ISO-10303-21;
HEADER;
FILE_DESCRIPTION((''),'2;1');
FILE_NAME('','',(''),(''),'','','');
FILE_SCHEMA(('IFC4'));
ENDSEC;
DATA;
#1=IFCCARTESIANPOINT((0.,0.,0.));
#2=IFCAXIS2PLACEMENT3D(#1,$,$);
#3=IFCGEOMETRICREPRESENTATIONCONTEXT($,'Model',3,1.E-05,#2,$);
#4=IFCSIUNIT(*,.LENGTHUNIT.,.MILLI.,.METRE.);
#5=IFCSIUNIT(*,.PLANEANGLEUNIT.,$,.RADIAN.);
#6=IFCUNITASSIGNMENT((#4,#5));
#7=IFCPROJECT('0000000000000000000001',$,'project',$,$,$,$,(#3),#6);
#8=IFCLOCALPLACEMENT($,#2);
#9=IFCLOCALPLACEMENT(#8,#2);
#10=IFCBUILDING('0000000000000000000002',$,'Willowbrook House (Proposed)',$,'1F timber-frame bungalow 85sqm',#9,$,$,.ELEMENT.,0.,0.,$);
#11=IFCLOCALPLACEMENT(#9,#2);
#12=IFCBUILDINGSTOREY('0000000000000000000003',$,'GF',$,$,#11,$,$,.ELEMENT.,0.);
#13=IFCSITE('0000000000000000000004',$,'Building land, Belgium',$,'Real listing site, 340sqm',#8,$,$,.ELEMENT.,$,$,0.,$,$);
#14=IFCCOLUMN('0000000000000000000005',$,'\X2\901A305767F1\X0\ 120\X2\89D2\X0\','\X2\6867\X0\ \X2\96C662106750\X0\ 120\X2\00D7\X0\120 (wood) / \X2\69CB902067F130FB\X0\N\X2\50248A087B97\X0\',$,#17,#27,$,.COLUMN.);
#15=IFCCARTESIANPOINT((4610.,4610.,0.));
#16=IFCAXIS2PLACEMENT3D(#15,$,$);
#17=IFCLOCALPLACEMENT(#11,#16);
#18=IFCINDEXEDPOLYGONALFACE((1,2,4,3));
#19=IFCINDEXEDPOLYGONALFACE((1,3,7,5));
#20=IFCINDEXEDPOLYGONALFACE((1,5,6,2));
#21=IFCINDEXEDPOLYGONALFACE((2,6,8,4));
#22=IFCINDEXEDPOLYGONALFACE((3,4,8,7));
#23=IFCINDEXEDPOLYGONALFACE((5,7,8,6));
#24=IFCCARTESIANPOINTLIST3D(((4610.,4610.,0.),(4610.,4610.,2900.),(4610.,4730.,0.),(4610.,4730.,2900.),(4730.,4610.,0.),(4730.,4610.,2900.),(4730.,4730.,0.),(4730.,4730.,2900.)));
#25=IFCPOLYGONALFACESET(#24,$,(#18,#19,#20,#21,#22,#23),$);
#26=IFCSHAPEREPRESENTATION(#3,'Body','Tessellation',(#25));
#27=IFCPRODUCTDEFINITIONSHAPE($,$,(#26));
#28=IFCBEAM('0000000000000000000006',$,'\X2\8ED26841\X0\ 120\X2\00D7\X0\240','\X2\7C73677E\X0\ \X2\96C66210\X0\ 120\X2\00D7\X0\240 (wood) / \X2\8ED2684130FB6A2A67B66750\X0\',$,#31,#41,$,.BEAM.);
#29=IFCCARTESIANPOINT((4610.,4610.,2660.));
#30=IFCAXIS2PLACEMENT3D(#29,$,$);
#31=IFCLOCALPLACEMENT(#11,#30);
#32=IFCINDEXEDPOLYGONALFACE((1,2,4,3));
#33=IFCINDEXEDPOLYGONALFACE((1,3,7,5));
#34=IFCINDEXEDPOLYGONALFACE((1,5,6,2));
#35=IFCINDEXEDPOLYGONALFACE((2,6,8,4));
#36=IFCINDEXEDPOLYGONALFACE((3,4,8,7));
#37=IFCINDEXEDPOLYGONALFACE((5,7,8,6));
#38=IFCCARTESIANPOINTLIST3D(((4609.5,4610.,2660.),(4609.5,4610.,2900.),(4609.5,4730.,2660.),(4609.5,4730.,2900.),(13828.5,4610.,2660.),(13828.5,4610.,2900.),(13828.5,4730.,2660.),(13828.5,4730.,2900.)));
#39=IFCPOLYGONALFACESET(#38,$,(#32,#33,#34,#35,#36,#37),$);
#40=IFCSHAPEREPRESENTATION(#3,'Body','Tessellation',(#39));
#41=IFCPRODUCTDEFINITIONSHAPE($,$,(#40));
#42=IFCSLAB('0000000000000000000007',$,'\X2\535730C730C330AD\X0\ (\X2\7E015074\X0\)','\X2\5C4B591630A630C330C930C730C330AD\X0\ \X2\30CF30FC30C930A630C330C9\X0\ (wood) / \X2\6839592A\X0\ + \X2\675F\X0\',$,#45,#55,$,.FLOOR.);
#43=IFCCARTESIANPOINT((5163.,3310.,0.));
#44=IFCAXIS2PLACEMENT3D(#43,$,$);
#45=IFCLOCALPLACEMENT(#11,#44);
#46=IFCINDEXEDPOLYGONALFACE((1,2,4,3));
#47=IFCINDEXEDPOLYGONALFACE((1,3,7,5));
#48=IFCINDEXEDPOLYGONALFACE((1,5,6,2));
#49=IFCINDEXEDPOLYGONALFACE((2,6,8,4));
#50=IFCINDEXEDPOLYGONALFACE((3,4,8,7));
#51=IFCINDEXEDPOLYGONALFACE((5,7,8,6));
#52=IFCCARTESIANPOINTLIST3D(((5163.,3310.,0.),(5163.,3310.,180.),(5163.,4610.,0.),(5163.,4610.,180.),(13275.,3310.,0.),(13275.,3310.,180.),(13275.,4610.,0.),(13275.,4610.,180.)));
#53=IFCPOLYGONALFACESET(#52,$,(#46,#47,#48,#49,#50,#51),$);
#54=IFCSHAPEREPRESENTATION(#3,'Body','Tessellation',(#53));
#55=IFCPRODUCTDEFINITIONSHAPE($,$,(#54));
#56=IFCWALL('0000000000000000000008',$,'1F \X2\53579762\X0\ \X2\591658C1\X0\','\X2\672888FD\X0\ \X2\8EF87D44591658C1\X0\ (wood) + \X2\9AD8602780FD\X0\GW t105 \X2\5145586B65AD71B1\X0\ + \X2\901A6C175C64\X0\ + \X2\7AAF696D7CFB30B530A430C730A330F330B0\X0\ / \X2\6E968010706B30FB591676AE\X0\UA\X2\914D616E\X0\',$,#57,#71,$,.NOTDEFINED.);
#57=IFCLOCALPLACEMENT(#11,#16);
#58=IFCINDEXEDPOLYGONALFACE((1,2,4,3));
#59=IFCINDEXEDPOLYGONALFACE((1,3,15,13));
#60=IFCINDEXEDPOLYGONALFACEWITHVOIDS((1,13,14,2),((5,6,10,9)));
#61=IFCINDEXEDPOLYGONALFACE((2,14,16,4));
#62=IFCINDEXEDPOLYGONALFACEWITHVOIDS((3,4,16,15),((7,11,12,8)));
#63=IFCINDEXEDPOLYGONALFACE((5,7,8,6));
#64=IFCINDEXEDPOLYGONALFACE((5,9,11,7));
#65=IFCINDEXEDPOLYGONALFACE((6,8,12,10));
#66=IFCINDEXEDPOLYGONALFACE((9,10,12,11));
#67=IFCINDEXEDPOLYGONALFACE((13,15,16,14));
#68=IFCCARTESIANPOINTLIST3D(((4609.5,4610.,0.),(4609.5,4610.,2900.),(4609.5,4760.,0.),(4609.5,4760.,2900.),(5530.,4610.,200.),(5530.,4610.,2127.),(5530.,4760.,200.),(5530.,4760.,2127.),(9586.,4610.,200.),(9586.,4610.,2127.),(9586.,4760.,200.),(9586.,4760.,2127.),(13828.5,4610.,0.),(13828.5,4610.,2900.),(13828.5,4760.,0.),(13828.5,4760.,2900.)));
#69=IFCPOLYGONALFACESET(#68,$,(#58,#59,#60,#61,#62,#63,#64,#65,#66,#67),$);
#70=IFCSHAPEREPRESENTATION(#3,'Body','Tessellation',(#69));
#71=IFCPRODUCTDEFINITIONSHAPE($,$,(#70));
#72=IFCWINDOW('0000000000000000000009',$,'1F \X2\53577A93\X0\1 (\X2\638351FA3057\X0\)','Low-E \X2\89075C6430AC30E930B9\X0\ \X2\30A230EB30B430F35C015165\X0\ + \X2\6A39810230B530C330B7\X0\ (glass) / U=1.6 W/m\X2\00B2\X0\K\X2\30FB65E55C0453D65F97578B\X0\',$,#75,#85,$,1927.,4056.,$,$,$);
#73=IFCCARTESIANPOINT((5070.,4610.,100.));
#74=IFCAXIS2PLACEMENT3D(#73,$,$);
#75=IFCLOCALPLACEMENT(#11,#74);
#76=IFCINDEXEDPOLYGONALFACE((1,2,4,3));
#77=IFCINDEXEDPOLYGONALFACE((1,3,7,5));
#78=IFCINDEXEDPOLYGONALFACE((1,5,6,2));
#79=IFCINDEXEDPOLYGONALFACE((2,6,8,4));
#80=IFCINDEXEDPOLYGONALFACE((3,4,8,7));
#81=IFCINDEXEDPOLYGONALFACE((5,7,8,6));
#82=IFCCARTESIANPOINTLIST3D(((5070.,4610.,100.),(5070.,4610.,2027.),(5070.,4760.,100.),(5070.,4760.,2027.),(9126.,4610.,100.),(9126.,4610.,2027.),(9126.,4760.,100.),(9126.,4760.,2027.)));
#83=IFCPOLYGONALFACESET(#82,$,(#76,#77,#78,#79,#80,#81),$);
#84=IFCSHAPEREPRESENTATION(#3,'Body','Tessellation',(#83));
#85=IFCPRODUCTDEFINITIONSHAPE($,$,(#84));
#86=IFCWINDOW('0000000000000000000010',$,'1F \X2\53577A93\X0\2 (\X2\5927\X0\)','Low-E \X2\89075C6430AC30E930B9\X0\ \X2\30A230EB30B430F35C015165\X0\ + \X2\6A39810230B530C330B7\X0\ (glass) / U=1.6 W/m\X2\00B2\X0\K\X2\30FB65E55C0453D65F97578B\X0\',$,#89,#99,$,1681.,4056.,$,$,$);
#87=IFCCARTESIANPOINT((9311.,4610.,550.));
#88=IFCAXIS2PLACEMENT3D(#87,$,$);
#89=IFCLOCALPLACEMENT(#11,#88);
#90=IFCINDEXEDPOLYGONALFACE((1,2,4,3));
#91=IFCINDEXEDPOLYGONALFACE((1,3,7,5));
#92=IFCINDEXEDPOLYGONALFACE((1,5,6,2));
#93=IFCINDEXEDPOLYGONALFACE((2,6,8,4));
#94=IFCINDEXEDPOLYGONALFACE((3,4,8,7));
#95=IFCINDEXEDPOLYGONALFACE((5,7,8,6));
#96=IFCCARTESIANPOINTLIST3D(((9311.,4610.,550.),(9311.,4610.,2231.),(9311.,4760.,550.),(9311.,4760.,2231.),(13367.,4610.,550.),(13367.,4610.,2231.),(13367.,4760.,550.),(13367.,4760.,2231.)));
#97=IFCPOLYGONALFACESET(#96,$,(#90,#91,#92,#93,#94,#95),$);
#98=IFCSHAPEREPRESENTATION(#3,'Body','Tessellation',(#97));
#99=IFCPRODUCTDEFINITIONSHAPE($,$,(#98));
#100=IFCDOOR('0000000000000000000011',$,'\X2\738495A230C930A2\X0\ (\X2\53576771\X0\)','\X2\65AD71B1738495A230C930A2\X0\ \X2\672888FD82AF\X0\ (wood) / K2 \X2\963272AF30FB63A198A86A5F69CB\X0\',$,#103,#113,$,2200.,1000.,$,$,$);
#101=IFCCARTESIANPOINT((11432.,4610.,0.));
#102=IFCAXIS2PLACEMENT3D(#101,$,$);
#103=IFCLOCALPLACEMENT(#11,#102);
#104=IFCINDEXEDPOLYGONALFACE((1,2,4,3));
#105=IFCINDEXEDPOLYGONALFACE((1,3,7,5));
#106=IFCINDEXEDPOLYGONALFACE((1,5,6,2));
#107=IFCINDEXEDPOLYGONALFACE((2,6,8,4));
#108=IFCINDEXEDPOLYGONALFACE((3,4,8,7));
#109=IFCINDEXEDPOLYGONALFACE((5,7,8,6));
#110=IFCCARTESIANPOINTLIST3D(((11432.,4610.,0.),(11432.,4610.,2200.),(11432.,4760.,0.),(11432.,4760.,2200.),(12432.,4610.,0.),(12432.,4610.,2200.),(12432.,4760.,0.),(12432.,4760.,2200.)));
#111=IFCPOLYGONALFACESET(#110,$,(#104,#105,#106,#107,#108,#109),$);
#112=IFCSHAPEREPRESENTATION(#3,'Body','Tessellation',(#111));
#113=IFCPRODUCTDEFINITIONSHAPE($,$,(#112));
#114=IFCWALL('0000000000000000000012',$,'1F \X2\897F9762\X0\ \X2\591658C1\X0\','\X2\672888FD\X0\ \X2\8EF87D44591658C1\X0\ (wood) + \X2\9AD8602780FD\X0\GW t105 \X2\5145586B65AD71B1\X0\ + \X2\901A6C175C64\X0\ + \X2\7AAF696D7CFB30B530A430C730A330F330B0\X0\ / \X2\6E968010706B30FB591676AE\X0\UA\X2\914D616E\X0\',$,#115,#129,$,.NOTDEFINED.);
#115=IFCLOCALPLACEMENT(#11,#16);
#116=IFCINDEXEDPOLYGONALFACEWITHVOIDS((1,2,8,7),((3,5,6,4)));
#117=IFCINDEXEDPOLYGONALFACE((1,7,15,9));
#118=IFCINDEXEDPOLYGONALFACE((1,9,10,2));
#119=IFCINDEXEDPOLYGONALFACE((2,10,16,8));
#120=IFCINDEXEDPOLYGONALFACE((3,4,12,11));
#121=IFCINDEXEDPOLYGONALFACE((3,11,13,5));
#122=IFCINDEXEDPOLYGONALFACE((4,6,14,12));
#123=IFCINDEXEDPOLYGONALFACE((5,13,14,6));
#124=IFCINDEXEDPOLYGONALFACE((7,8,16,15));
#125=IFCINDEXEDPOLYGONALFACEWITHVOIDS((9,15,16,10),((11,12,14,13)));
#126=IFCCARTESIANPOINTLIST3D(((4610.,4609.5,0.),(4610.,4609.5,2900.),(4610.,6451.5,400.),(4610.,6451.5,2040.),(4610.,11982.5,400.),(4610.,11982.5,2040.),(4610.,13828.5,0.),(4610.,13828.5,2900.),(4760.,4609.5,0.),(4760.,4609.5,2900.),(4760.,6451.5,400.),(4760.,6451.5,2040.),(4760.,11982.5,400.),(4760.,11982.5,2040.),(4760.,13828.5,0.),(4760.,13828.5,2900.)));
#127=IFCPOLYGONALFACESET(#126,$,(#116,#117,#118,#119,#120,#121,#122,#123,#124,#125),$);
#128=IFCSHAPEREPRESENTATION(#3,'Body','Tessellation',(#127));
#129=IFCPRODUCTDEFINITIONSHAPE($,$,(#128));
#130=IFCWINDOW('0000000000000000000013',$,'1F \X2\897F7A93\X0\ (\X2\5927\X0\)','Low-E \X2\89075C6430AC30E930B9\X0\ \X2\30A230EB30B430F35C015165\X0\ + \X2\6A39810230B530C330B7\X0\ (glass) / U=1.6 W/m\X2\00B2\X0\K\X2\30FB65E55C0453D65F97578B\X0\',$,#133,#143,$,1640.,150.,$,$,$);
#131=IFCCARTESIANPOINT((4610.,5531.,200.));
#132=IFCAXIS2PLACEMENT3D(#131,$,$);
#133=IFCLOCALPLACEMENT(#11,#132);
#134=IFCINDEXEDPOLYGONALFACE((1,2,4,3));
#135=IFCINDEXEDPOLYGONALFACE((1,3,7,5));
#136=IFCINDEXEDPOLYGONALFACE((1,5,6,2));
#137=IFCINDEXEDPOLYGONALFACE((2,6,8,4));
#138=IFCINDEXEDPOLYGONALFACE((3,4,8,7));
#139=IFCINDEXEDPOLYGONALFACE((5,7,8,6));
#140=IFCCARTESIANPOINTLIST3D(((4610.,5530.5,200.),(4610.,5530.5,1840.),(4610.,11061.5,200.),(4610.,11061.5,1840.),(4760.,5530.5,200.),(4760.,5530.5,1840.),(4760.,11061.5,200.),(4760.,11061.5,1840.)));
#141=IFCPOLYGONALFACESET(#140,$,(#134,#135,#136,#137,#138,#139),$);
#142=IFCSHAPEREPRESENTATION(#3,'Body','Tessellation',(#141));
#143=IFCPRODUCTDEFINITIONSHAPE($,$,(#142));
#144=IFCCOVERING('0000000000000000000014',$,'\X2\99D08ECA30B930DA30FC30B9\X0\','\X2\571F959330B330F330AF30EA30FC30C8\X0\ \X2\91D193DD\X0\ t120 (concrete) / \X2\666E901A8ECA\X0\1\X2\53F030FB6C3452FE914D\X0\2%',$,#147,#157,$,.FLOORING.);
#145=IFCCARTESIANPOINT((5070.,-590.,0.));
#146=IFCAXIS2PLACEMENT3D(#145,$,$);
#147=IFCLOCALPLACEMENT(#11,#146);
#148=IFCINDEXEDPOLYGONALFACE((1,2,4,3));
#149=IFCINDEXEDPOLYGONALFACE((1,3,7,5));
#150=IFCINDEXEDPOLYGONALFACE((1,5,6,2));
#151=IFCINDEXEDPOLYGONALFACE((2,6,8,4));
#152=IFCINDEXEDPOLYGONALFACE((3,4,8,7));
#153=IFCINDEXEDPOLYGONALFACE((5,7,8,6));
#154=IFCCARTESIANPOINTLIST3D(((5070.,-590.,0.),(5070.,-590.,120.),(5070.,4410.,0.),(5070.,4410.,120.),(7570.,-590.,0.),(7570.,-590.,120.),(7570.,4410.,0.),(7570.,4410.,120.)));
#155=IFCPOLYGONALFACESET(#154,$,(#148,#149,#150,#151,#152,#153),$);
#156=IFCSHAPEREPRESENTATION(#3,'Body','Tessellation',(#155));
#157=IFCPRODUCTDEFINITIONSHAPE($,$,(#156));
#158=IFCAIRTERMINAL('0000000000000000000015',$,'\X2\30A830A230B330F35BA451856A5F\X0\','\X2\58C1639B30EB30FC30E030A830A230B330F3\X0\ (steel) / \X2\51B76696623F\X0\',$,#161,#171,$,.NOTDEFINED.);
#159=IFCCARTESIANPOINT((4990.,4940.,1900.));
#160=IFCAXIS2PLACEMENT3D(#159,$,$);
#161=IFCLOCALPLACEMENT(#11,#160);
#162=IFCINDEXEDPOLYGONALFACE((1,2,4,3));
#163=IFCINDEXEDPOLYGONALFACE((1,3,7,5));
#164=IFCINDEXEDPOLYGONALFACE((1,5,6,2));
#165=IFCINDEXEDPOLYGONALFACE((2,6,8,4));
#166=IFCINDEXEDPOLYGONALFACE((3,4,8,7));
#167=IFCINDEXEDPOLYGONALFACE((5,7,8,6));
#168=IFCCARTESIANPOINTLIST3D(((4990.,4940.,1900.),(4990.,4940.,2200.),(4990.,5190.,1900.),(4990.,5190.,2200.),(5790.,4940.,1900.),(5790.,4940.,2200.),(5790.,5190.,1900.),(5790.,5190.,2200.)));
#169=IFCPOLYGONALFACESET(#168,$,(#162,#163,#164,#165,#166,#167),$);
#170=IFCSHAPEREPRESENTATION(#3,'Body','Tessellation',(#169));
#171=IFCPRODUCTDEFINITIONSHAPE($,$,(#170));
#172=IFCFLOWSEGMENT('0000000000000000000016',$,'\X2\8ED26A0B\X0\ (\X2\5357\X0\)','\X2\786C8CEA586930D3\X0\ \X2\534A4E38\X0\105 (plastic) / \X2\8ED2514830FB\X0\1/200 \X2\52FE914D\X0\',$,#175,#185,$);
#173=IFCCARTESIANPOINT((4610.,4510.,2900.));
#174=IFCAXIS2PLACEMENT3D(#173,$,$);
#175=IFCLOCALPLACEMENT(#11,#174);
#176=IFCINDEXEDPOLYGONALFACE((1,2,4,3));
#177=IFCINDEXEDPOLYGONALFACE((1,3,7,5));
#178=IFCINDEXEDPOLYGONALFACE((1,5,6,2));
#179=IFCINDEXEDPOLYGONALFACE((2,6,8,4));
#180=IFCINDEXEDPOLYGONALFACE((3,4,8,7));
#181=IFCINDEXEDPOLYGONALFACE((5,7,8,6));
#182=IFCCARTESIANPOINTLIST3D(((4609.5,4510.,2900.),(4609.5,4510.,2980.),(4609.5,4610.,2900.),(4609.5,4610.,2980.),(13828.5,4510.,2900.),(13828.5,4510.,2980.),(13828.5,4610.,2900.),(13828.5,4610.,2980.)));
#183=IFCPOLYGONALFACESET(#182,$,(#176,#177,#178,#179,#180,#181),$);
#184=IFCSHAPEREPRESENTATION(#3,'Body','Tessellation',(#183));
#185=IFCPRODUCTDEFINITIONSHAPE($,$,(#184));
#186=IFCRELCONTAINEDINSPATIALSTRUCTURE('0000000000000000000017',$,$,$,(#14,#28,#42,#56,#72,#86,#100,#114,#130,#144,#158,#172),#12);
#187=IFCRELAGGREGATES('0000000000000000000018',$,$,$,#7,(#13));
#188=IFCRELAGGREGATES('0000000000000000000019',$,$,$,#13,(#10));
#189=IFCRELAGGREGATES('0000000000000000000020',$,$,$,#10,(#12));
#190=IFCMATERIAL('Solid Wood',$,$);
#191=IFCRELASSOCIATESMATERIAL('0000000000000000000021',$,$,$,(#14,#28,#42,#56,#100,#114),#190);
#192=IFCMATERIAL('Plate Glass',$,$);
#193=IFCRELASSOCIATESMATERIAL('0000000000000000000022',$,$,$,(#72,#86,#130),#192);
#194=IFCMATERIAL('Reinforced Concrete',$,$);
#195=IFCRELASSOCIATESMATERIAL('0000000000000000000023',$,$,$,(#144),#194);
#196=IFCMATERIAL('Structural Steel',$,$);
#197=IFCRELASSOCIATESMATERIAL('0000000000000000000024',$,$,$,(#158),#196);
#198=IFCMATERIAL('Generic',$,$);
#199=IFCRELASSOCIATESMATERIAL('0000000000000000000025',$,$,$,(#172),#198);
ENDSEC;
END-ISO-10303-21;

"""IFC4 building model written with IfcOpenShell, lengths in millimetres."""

from ifc_helpers import new_model, si_unit, frame, frame_2d, origin, place, context, project, spatial, rectangle, extrude, material, element, fill, save


model = new_model("IFC4")

# Units and contexts
model_context = context("Model", 3, precision=1e-05, world=origin())
ifc_project = project(units=[si_unit("LENGTHUNIT", "METRE", prefix="MILLI"), si_unit("PLANEANGLEUNIT", "RADIAN")], contexts=[model_context])

# Site, building, storey
site_placement = place(None, origin())
site = spatial("IfcSite", under=ifc_project, at=site_placement, Name="Building land, Belgium", ObjectType="Real listing site, 340sqm", CompositionType="ELEMENT", RefElevation=0.0)
building_placement = place(site_placement, origin())
building = spatial("IfcBuilding", under=site, at=building_placement, Name="Willowbrook House (Proposed)", ObjectType="1F timber-frame bungalow 85sqm", CompositionType="ELEMENT", ElevationOfRefHeight=0.0, ElevationOfTerrain=0.0)
storey_placement = place(building_placement, origin())
storey = spatial("IfcBuildingStorey", under=building, at=storey_placement, Name="GF", CompositionType="ELEMENT", Elevation=0.0)

# Column
ifc_material_1 = material(Name="Solid Wood")
column_1_placement = place(storey_placement, frame((4610.0, 4610.0, 0.0)))
element("IfcColumn", 1, at=column_1_placement, inside=storey, material=ifc_material_1, Name="通し柱 120角", Description="桧 集成材 120×120 (wood) / 構造柱・N値計算", PredefinedType="COLUMN", context=model_context, shape_type="SweptSolid", body=[
    extrude(rectangle(XDim=120.0, YDim=120.0, at=frame_2d((60.0, 60.0))), frame((4610.0, 4610.0, 0.0)), (0.0, 0.0, 1.0), 2900.0),
])

# Beam
beam_1_placement = place(storey_placement, frame((4610.0, 4610.0, 2660.0)))
element("IfcBeam", 2, at=beam_1_placement, inside=storey, material=ifc_material_1, Name="軒桁 120×240", Description="米松 集成 120×240 (wood) / 軒桁・横架材", PredefinedType="BEAM", context=model_context, shape_type="SweptSolid", body=[
    extrude(rectangle(XDim=9219.0, YDim=120.0, at=frame_2d((4609.0, 60.0))), frame((4610.0, 4610.0, 2660.0)), (0.0, 0.0, 1.0), 240.0),
])

# Slab
ifc_material_2 = material(Name="Reinforced Concrete")
slab_1_placement = place(storey_placement, frame((5163.0, 3310.0, 0.0)))
element("IfcSlab", 3, at=slab_1_placement, inside=storey, material=ifc_material_1, Name="南デッキ (縁側)", Description="屋外ウッドデッキ ハードウッド (wood) / 根太 + 束", PredefinedType="FLOOR", context=model_context, shape_type="SweptSolid", body=[
    extrude(rectangle(XDim=8112.0, YDim=1300.0, at=frame_2d((4056.0, 650.0))), frame((5163.0, 3310.0, 0.0)), (0.0, 0.0, 1.0), 180.0),
])

# Wall, openings, windows, door
wall_1_placement = place(storey_placement, frame((4610.0, 4610.0, 0.0)))
wall_1 = element("IfcWall", 4, at=wall_1_placement, inside=storey, material=ifc_material_1, Name="1F 南面 外壁", Description="木製 軸組外壁 (wood) + 高性能GW t105 充填断熱 + 通気層 + 窯業系サイディング / 準耐火・外皮UA配慮", PredefinedType="NOTDEFINED", context=model_context, shape_type="SweptSolid", body=[
    extrude(rectangle(XDim=9219.0, YDim=150.0, at=frame_2d((4609.0, 75.0))), frame((4610.0, 4610.0, 0.0)), (0.0, 0.0, 1.0), 2900.0),
])
opening_1_placement = place(storey_placement, frame((5070.0, 4610.0, 100.0)))
opening_1 = element("IfcOpeningElement", 5, at=opening_1_placement, cuts=wall_1, PredefinedType="NOTDEFINED", context=model_context, shape_type="SweptSolid", body=[
    extrude(rectangle(XDim=4056.0, YDim=150.0, at=frame_2d((2028.0, 75.0))), frame((5070.0, 4610.0, 100.0)), (0.0, 0.0, 1.0), 1927.0),
])
opening_2_placement = place(storey_placement, frame((9311.0, 4610.0, 550.0)))
opening_2 = element("IfcOpeningElement", 6, at=opening_2_placement, cuts=wall_1, PredefinedType="NOTDEFINED", context=model_context, shape_type="SweptSolid", body=[
    extrude(rectangle(XDim=4056.0, YDim=150.0, at=frame_2d((2028.0, 75.0))), frame((9311.0, 4610.0, 550.0)), (0.0, 0.0, 1.0), 1681.0),
])
opening_3_placement = place(storey_placement, frame((11432.0, 4610.0, 0.0)))
opening_3 = element("IfcOpeningElement", 7, at=opening_3_placement, cuts=wall_1, PredefinedType="NOTDEFINED", context=model_context, shape_type="SweptSolid", body=[
    extrude(rectangle(XDim=1000.0, YDim=150.0, at=frame_2d((500.0, 75.0))), frame((11432.0, 4610.0, 0.0)), (0.0, 0.0, 1.0), 2200.0),
])
ifc_material_3 = material(Name="Plate Glass")
window_1_placement = place(storey_placement, frame((5070.0, 4610.0, 100.0)))
window_1 = element("IfcWindow", 8, at=window_1_placement, inside=storey, material=ifc_material_3, Name="1F 南窓1 (掃出し)", Description="Low-E 複層ガラス アルゴン封入 + 樹脂サッシ (glass) / U=1.6 W/m²K・日射取得型", OverallHeight=1927.0, OverallWidth=4056.0, context=model_context, shape_type="SweptSolid", body=[
    extrude(rectangle(XDim=4056.0, YDim=150.0, at=frame_2d((2028.0, 75.0))), frame((5070.0, 4610.0, 100.0)), (0.0, 0.0, 1.0), 1927.0),
])
fill(opening_1, window_1)
window_2_placement = place(storey_placement, frame((9311.0, 4610.0, 550.0)))
window_2 = element("IfcWindow", 9, at=window_2_placement, inside=storey, material=ifc_material_3, Name="1F 南窓2 (大)", Description="Low-E 複層ガラス アルゴン封入 + 樹脂サッシ (glass) / U=1.6 W/m²K・日射取得型", OverallHeight=1681.0, OverallWidth=4056.0, context=model_context, shape_type="SweptSolid", body=[
    extrude(rectangle(XDim=4056.0, YDim=150.0, at=frame_2d((2028.0, 75.0))), frame((9311.0, 4610.0, 550.0)), (0.0, 0.0, 1.0), 1681.0),
])
fill(opening_2, window_2)
door_placement = place(storey_placement, frame((11432.0, 4610.0, 0.0)))
door = element("IfcDoor", 10, at=door_placement, inside=storey, material=ifc_material_1, Name="玄関ドア (南東)", Description="断熱玄関ドア 木製芯 (wood) / K2 防犯・採風機構", OverallHeight=2200.0, OverallWidth=1000.0, context=model_context, shape_type="SweptSolid", body=[
    extrude(rectangle(XDim=1000.0, YDim=150.0, at=frame_2d((500.0, 75.0))), frame((11432.0, 4610.0, 0.0)), (0.0, 0.0, 1.0), 2200.0),
])
fill(opening_3, door)

# Wall, opening, window
wall_2_placement = place(storey_placement, frame((4610.0, 4610.0, 0.0)))
wall_2 = element("IfcWall", 11, at=wall_2_placement, inside=storey, material=ifc_material_1, Name="1F 西面 外壁", Description="木製 軸組外壁 (wood) + 高性能GW t105 充填断熱 + 通気層 + 窯業系サイディング / 準耐火・外皮UA配慮", PredefinedType="NOTDEFINED", context=model_context, shape_type="SweptSolid", body=[
    extrude(rectangle(XDim=150.0, YDim=9219.0, at=frame_2d((75.0, 4609.0))), frame((4610.0, 4610.0, 0.0)), (0.0, 0.0, 1.0), 2900.0),
])
opening_4_placement = place(storey_placement, frame((4610.0, 5531.0, 200.0)))
opening_4 = element("IfcOpeningElement", 12, at=opening_4_placement, cuts=wall_2, PredefinedType="NOTDEFINED", context=model_context, shape_type="SweptSolid", body=[
    extrude(rectangle(XDim=150.0, YDim=5531.0, at=frame_2d((75.0, 2765.0))), frame((4610.0, 5531.0, 200.0)), (0.0, 0.0, 1.0), 1640.0),
])
window_3_placement = place(storey_placement, frame((4610.0, 5531.0, 200.0)))
window_3 = element("IfcWindow", 13, at=window_3_placement, inside=storey, material=ifc_material_3, Name="1F 西窓 (大)", Description="Low-E 複層ガラス アルゴン封入 + 樹脂サッシ (glass) / U=1.6 W/m²K・日射取得型", OverallHeight=1640.0, OverallWidth=150.0, context=model_context, shape_type="SweptSolid", body=[
    extrude(rectangle(XDim=150.0, YDim=5531.0, at=frame_2d((75.0, 2765.0))), frame((4610.0, 5531.0, 200.0)), (0.0, 0.0, 1.0), 1640.0),
])
fill(opening_4, window_3)

# Shared definitions
ifc_material_4 = material(Name="Structural Steel")

# Covering
ifc_material_5 = material(Name="Generic")
covering_1_placement = place(storey_placement, frame((5070.0, -590.0, 0.0)))
element("IfcCovering", 14, at=covering_1_placement, inside=storey, material=ifc_material_2, Name="駐車スペース", Description="土間コンクリート 金鏝 t120 (concrete) / 普通車1台・水勾配2%", PredefinedType="FLOORING", context=model_context, shape_type="SweptSolid", body=[
    extrude(rectangle(XDim=2500.0, YDim=5000.0, at=frame_2d((1250.0, 2500.0))), frame((5070.0, -590.0, 0.0)), (0.0, 0.0, 1.0), 120.0),
])

# Air terminal
air_terminal_placement = place(storey_placement, frame((4990.0, 4940.0, 1900.0)))
element("IfcAirTerminal", 15, at=air_terminal_placement, inside=storey, material=ifc_material_4, Name="エアコン室内機", Description="壁掛ルームエアコン (steel) / 冷暖房", PredefinedType="NOTDEFINED", context=model_context, shape_type="SweptSolid", body=[
    extrude(rectangle(XDim=800.0, YDim=250.0, at=frame_2d((400.0, 125.0))), frame((4990.0, 4940.0, 1900.0)), (0.0, 0.0, 1.0), 300.0),
])

# Flow segment
flow_segment_1_placement = place(storey_placement, frame((4610.0, 4510.0, 2900.0)))
element("IfcFlowSegment", 16, at=flow_segment_1_placement, inside=storey, material=ifc_material_5, Name="軒樋 (南)", Description="硬質塩ビ 半丸105 (plastic) / 軒先・1/200 勾配", context=model_context, shape_type="SweptSolid", body=[
    extrude(rectangle(XDim=9219.0, YDim=100.0, at=frame_2d((4609.0, 50.0))), frame((4610.0, 4510.0, 2900.0)), (0.0, 0.0, 1.0), 80.0),
])

save(model, "model.ifc")
